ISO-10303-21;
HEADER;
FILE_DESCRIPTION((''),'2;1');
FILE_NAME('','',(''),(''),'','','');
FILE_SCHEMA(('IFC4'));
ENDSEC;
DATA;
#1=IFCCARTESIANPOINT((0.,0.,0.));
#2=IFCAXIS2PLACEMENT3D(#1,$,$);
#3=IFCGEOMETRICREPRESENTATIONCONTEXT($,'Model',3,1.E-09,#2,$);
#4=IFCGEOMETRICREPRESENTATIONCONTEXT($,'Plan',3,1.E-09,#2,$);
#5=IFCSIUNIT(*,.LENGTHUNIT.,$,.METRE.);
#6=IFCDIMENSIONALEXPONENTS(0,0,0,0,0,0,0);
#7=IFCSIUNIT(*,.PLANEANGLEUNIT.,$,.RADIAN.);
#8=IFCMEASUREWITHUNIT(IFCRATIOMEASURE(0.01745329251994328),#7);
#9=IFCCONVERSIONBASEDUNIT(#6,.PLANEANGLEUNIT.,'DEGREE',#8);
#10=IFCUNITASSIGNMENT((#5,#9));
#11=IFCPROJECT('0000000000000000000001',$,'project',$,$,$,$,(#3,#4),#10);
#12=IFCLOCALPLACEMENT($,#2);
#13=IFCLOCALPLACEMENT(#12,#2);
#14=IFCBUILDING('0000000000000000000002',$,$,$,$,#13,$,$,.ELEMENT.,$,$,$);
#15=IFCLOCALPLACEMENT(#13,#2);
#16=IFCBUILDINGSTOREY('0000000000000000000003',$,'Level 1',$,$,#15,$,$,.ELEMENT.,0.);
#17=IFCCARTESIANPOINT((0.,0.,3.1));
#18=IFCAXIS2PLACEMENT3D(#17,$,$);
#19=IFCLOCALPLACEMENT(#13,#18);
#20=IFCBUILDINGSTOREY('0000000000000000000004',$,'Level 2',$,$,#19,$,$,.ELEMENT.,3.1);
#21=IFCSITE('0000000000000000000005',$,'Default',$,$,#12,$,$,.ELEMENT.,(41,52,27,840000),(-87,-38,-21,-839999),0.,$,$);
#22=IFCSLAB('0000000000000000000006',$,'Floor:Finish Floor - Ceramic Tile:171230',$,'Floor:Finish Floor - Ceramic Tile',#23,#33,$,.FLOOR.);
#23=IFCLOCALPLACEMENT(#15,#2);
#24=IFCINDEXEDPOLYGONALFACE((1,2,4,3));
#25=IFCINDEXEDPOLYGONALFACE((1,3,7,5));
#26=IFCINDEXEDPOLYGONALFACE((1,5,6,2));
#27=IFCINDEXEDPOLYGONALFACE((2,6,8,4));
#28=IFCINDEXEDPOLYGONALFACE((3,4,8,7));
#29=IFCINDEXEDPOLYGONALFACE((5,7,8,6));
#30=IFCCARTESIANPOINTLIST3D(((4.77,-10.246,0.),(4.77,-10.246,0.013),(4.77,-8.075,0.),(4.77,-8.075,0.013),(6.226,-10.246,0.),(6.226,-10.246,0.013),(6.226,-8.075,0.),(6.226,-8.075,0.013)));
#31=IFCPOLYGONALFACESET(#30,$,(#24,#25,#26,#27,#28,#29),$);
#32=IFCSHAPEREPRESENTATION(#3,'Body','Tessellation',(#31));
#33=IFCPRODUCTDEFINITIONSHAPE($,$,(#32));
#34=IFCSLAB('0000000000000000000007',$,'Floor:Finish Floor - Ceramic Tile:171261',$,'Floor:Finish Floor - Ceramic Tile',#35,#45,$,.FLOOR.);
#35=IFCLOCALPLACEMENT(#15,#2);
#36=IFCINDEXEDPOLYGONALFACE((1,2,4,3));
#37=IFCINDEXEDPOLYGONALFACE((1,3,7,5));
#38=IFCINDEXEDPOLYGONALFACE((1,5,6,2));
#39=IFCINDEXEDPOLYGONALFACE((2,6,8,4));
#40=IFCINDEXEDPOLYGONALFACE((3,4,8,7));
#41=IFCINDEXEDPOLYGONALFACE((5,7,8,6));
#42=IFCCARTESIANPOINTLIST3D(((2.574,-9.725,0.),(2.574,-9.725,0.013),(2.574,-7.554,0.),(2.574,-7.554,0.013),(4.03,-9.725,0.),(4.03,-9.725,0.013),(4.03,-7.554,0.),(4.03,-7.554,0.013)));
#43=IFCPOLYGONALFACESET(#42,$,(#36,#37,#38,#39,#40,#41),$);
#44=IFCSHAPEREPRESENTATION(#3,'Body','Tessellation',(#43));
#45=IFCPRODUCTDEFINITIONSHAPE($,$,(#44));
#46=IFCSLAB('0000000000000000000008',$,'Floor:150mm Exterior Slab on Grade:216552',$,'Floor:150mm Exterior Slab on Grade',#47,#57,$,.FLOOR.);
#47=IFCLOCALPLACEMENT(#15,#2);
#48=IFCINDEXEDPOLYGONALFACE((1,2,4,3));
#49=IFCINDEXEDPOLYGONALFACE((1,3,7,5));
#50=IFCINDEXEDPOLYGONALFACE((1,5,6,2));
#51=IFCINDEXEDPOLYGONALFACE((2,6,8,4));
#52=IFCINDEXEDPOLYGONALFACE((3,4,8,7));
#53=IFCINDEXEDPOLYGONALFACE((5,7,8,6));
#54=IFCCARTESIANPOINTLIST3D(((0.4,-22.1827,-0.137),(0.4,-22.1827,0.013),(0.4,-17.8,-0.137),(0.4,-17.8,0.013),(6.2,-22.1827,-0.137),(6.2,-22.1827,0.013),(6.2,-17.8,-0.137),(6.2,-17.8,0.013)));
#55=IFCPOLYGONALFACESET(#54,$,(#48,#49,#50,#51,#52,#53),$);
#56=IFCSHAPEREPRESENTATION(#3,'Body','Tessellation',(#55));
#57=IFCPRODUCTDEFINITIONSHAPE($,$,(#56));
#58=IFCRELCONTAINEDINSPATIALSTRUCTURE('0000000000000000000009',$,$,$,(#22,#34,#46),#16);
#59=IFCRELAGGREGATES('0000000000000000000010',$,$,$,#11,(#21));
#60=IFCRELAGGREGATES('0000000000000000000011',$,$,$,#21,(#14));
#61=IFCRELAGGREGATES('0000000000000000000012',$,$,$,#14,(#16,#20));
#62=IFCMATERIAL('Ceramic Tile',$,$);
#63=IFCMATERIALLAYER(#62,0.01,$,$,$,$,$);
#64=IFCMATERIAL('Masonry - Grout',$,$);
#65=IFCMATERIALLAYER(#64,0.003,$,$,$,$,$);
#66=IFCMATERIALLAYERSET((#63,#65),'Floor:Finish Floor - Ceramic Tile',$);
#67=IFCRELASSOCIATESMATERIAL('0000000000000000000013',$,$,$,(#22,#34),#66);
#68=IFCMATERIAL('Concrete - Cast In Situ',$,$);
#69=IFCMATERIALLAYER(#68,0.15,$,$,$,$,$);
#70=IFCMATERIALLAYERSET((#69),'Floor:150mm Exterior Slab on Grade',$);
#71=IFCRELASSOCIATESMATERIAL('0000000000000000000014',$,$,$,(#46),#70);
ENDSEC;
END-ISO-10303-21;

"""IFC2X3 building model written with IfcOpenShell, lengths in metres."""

from ifc_helpers import new_model, entity, si_unit, converted_unit, frame, frame_2d, origin, origin_2d_with_axis, place, context, project, spatial, rectangle, extrude, material, layer, layer_set, layer_usage, element, save


model = new_model("IFC2X3")

# Units and contexts
model_context = context("Model", 3, precision=1e-09, world=origin())
plan_context = context("Plan", 3, precision=1e-09, world=origin())
ifc_project = project(units=[si_unit("LENGTHUNIT", "METRE"), converted_unit("PLANEANGLEUNIT", "DEGREE", entity("IfcRatioMeasure", 0.01745329251994328), si_unit("PLANEANGLEUNIT", "RADIAN"), dimensions=[0, 0, 0, 0, 0, 0, 0])], contexts=[model_context, plan_context])

# Site, building, storey
site_placement = place(None, origin())
site = spatial("IfcSite", under=ifc_project, at=site_placement, Name="Default", CompositionType="ELEMENT", RefLatitude=(41, 52, 27, 840000), RefLongitude=(-87, -38, -21, -839999), RefElevation=0.0)
building_placement = place(site_placement, origin())
building = spatial("IfcBuilding", under=site, at=building_placement, CompositionType="ELEMENT")
storey_1_placement = place(building_placement, origin())
storey_1 = spatial("IfcBuildingStorey", under=building, at=storey_1_placement, Name="Level 1", CompositionType="ELEMENT", Elevation=0.0)

# Slabs
ifc_material_1 = material(Name="Ceramic Tile")
ifc_layer_1 = layer(ifc_material_1, 0.01)
ifc_material_2 = material(Name="Masonry - Grout")
ifc_layer_2 = layer(ifc_material_2, 0.003)
ifc_layer_set_1 = layer_set([ifc_layer_1, ifc_layer_2], Name="Floor:Finish Floor - Ceramic Tile")
ifc_layer_usage_1 = layer_usage(ifc_layer_set_1, "AXIS3", "POSITIVE", 0.0)
slab_1_placement = place(storey_1_placement, frame((4.77, -10.246, 0.0)))
element("IfcSlab", 1, at=slab_1_placement, inside=storey_1, material=ifc_layer_usage_1, Name="Floor:Finish Floor - Ceramic Tile:171230", ObjectType="Floor:Finish Floor - Ceramic Tile", PredefinedType="FLOOR", context=model_context, shape_type="SweptSolid", body=[
    extrude(rectangle(XDim=1.456, YDim=2.171, at=frame_2d((0.0, 0.0), x_axis=(-1.0, 0.0))), frame((0.728, 1.0855, 0.013), z_axis=(0.0, 0.0, -1.0), x_axis=(-1.0, 0.0, 0.0)), (0.0, 0.0, 1.0), 0.013),
])
ifc_layer_usage_2 = layer_usage(ifc_layer_set_1, "AXIS3", "POSITIVE", 0.0)
slab_2_placement = place(storey_1_placement, frame((2.574, -9.725, 0.0)))
element("IfcSlab", 2, at=slab_2_placement, inside=storey_1, material=ifc_layer_usage_2, Name="Floor:Finish Floor - Ceramic Tile:171261", ObjectType="Floor:Finish Floor - Ceramic Tile", PredefinedType="FLOOR", context=model_context, shape_type="SweptSolid", body=[
    extrude(rectangle(XDim=2.171, YDim=1.456, at=frame_2d((0.0, 0.0), x_axis=(0.0, -1.0))), frame((0.728, 1.0855, 0.013), z_axis=(0.0, 0.0, -1.0), x_axis=(-1.0, 0.0, 0.0)), (0.0, 0.0, 1.0), 0.013),
])
ifc_material_3 = material(Name="Concrete - Cast In Situ")
ifc_layer_3 = layer(ifc_material_3, 0.15)
ifc_layer_set_2 = layer_set([ifc_layer_3], Name="Floor:150mm Exterior Slab on Grade")
ifc_layer_usage_3 = layer_usage(ifc_layer_set_2, "AXIS3", "POSITIVE", 0.0)
slab_3_placement = place(storey_1_placement, frame((0.4, -22.1827, -0.137)))
element("IfcSlab", 3, at=slab_3_placement, inside=storey_1, material=ifc_layer_usage_3, Name="Floor:150mm Exterior Slab on Grade:216552", ObjectType="Floor:150mm Exterior Slab on Grade", PredefinedType="FLOOR", context=model_context, shape_type="SweptSolid", body=[
    extrude(rectangle(XDim=5.8, YDim=4.3827, at=origin_2d_with_axis()), frame((2.9, 2.1914, 0.15), z_axis=(0.0, 0.0, -1.0), x_axis=(-1.0, 0.0, 0.0)), (0.0, 0.0, 1.0), 0.15),
])

# Shared definitions
storey_2_placement = place(building_placement, frame((0.0, 0.0, 3.1)))
storey_2 = spatial("IfcBuildingStorey", under=building, at=storey_2_placement, Name="Level 2", CompositionType="ELEMENT", Elevation=3.1)

save(model, "model.ifc")
